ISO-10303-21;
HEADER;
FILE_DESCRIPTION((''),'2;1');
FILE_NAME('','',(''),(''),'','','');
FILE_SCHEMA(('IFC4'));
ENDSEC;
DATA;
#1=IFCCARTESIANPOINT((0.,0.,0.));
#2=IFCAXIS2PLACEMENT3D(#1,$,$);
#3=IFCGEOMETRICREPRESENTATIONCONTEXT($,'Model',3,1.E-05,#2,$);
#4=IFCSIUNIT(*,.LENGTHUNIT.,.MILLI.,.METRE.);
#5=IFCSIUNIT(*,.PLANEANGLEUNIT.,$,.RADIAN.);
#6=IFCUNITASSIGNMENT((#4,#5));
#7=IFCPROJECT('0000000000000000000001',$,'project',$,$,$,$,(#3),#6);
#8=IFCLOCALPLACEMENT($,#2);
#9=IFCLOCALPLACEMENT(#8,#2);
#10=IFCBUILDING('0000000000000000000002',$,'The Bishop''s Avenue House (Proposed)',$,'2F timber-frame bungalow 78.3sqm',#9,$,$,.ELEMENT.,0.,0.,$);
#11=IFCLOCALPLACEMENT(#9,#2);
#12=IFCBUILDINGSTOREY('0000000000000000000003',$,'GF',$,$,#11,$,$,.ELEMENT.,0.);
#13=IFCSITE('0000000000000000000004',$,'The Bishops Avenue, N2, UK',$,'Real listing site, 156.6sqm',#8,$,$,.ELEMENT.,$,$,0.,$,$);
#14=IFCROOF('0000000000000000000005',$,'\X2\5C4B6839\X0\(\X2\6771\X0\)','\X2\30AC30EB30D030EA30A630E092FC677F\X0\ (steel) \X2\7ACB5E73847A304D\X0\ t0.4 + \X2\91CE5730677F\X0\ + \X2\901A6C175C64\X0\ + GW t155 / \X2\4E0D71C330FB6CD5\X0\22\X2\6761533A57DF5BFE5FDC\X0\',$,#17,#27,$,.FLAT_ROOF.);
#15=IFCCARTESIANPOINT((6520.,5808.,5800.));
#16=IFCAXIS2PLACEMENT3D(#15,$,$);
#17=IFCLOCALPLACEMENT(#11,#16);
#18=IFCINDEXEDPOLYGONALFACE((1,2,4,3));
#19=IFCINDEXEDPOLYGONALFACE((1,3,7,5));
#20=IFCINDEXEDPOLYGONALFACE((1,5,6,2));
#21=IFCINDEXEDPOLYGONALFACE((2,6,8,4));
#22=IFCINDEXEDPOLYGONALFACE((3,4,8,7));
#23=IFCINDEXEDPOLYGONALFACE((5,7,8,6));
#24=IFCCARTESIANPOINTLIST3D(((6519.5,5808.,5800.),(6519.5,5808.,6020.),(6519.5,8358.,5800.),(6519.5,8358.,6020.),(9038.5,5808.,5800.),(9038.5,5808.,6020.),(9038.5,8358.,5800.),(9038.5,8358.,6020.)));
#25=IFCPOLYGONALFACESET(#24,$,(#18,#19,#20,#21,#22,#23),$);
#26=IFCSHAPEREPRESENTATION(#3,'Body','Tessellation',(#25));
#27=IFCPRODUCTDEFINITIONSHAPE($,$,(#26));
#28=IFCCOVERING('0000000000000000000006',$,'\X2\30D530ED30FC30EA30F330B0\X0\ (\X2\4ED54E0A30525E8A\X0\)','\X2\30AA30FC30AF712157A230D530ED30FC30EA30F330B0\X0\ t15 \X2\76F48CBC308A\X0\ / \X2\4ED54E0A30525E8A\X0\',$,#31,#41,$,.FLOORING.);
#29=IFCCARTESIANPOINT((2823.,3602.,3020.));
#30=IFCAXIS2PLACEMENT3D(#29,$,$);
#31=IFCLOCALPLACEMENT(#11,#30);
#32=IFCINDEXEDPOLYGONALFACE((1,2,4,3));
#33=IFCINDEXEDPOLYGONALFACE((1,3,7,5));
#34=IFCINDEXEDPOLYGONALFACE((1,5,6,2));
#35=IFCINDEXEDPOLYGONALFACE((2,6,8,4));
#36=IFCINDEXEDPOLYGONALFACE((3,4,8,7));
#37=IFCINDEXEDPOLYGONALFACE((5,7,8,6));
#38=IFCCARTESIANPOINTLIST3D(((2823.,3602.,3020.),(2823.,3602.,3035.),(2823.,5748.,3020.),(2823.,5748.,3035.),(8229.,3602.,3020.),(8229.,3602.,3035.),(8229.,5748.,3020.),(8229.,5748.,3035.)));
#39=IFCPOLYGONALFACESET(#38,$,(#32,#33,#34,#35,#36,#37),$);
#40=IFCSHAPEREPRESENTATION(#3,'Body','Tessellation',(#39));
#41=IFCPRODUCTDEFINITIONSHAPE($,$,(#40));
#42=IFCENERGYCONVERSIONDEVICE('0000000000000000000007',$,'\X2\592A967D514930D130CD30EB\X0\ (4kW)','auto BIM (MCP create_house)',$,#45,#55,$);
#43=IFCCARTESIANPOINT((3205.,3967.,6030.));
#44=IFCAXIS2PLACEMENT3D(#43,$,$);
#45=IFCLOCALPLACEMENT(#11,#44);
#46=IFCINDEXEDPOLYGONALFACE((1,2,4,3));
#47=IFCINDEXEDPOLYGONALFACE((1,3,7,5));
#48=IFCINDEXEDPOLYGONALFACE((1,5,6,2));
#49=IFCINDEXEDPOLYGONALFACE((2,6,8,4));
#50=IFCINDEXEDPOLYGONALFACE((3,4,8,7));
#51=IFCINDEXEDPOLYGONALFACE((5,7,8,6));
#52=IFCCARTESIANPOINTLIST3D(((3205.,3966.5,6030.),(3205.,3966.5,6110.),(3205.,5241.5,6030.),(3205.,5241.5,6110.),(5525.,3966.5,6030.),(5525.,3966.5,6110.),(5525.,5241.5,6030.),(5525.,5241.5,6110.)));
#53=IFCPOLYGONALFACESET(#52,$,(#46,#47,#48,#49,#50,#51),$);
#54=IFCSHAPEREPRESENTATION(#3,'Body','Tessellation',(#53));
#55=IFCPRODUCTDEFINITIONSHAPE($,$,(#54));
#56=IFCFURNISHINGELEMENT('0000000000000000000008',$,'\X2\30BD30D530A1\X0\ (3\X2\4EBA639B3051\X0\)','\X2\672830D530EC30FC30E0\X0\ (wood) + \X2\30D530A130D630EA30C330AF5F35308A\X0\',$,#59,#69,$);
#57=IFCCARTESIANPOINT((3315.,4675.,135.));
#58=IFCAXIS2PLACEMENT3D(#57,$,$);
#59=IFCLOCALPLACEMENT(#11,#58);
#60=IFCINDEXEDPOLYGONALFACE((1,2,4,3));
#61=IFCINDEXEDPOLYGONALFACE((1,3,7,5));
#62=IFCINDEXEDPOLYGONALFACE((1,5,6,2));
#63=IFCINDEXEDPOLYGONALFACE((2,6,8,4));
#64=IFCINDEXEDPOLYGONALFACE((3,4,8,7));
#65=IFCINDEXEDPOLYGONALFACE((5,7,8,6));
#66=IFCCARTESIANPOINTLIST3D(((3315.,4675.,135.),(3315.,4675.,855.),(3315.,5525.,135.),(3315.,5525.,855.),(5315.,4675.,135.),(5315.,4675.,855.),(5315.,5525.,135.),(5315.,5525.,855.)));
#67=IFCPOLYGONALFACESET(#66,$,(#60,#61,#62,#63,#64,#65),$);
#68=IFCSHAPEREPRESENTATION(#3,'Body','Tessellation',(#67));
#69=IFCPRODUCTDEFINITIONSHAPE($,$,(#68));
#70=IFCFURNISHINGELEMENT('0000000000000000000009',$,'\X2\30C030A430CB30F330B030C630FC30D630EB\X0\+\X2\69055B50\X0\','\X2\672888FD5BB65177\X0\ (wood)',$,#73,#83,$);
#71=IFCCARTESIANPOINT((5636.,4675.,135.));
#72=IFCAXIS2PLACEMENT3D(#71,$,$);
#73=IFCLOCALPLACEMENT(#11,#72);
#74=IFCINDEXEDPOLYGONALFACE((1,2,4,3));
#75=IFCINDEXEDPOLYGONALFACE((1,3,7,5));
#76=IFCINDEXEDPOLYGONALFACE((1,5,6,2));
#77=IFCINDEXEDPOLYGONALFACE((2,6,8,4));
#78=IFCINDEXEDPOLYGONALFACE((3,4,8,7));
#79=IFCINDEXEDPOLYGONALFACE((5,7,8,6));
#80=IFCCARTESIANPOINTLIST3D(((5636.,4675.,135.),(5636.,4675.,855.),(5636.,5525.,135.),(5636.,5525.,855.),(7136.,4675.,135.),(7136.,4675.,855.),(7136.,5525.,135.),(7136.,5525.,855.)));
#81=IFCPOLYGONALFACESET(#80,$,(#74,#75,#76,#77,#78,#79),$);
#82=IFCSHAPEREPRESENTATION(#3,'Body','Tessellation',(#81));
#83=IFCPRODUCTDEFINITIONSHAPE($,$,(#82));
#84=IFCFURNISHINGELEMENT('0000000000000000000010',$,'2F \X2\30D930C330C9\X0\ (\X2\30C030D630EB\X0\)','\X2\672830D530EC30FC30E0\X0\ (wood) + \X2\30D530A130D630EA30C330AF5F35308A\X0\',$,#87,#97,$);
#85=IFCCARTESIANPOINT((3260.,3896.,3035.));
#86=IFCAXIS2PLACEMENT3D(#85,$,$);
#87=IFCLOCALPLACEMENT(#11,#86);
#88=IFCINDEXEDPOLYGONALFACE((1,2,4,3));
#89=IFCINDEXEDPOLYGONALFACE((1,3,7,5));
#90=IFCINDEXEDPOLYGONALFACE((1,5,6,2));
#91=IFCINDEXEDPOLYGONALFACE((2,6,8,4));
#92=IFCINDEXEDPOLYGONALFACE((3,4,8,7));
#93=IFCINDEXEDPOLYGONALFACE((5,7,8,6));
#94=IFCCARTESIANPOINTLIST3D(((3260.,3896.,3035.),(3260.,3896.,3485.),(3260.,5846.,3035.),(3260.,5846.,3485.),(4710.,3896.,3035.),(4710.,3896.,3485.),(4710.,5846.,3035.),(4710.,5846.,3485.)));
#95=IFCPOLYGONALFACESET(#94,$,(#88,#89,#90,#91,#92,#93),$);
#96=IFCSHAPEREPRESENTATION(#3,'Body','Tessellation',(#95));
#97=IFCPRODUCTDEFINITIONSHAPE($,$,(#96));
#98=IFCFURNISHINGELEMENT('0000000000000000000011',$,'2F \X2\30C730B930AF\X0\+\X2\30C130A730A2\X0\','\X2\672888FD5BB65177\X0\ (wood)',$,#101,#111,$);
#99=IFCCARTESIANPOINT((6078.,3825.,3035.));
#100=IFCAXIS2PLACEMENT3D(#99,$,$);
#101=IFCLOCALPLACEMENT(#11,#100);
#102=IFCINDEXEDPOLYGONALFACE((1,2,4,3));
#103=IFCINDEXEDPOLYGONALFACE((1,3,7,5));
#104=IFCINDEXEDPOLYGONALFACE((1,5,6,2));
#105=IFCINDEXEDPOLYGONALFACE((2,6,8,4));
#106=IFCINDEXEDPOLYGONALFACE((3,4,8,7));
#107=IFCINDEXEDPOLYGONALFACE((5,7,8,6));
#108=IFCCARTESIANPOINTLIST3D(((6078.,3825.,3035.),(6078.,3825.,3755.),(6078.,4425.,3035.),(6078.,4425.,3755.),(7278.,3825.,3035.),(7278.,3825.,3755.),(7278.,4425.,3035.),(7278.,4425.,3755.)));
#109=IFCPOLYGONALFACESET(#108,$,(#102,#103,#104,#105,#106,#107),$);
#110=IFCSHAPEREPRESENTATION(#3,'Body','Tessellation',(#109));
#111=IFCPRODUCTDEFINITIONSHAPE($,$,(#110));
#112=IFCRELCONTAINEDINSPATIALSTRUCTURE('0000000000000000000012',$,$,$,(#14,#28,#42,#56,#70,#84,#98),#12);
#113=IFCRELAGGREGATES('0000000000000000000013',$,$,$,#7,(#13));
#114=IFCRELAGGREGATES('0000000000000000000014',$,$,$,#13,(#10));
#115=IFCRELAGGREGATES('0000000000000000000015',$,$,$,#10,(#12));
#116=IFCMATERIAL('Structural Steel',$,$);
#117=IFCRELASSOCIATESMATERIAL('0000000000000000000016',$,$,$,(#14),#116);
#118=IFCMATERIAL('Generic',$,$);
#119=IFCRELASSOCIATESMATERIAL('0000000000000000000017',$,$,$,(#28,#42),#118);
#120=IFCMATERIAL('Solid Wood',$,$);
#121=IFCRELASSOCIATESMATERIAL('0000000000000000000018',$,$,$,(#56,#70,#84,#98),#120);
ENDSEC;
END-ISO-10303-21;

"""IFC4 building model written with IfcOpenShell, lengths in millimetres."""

from ifc_helpers import new_model, si_unit, frame, frame_2d, origin, place, context, project, spatial, rectangle, extrude, material, element, save


model = new_model("IFC4")

# Units and contexts
model_context = context("Model", 3, precision=1e-05, world=origin())
ifc_project = project(units=[si_unit("LENGTHUNIT", "METRE", prefix="MILLI"), si_unit("PLANEANGLEUNIT", "RADIAN")], contexts=[model_context])

# Site, building, storey
site_placement = place(None, origin())
site = spatial("IfcSite", under=ifc_project, at=site_placement, Name="The Bishops Avenue, N2, UK", ObjectType="Real listing site, 156.6sqm", CompositionType="ELEMENT", RefElevation=0.0)
building_placement = place(site_placement, origin())
building = spatial("IfcBuilding", under=site, at=building_placement, Name="The Bishop's Avenue House (Proposed)", ObjectType="2F timber-frame bungalow 78.3sqm", CompositionType="ELEMENT", ElevationOfRefHeight=0.0, ElevationOfTerrain=0.0)
storey_placement = place(building_placement, origin())
storey = spatial("IfcBuildingStorey", under=building, at=storey_placement, Name="GF", CompositionType="ELEMENT", Elevation=0.0)

# Shared definitions
ifc_material_1 = material(Name="Solid Wood")

# Roof
ifc_material_2 = material(Name="Structural Steel")
roof_1_placement = place(storey_placement, frame((6520.0, 5808.0, 5800.0)))
element("IfcRoof", 1, at=roof_1_placement, inside=storey, material=ifc_material_2, Name="屋根(東)", Description="ガルバリウム鋼板 (steel) 立平葺き t0.4 + 野地板 + 通気層 + GW t155 / 不燃・法22条区域対応", PredefinedType="FLAT_ROOF", context=model_context, shape_type="SweptSolid", body=[
    extrude(rectangle(XDim=2519.0, YDim=2550.0, at=frame_2d((1259.0, 1275.0))), frame((6520.0, 5808.0, 5800.0)), (0.0, 0.0, 1.0), 220.0),
])

# Covering
ifc_material_3 = material(Name="Generic")
covering_placement = place(storey_placement, frame((2823.0, 3602.0, 3020.0)))
element("IfcCovering", 2, at=covering_placement, inside=storey, material=ifc_material_3, Name="フローリング (仕上げ床)", Description="オーク無垢フローリング t15 直貼り / 仕上げ床", PredefinedType="FLOORING", context=model_context, shape_type="SweptSolid", body=[
    extrude(rectangle(XDim=5406.0, YDim=2146.0, at=frame_2d((2703.0, 1073.0))), frame((2823.0, 3602.0, 3020.0)), (0.0, 0.0, 1.0), 15.0),
])

# Energy conversion device
energy_conversion_device_placement = place(storey_placement, frame((3205.0, 3967.0, 6030.0)))
element("IfcEnergyConversionDevice", 3, at=energy_conversion_device_placement, inside=storey, material=ifc_material_3, Name="太陽光パネル (4kW)", Description="auto BIM (MCP create_house)", context=model_context, shape_type="SweptSolid", body=[
    extrude(rectangle(XDim=2320.0, YDim=1275.0, at=frame_2d((1160.0, 637.0))), frame((3205.0, 3967.0, 6030.0)), (0.0, 0.0, 1.0), 80.0),
])

# Furnishing elements
furnishing_1_placement = place(storey_placement, frame((3315.0, 4675.0, 135.0)))
element("IfcFurnishingElement", 4, at=furnishing_1_placement, inside=storey, material=ifc_material_1, Name="ソファ (3人掛け)", Description="木フレーム (wood) + ファブリック張り", context=model_context, shape_type="SweptSolid", body=[
    extrude(rectangle(XDim=2000.0, YDim=850.0, at=frame_2d((1000.0, 425.0))), frame((3315.0, 4675.0, 135.0)), (0.0, 0.0, 1.0), 720.0),
])
furnishing_2_placement = place(storey_placement, frame((5636.0, 4675.0, 135.0)))
element("IfcFurnishingElement", 5, at=furnishing_2_placement, inside=storey, material=ifc_material_1, Name="ダイニングテーブル+椅子", Description="木製家具 (wood)", context=model_context, shape_type="SweptSolid", body=[
    extrude(rectangle(XDim=1500.0, YDim=850.0, at=frame_2d((750.0, 425.0))), frame((5636.0, 4675.0, 135.0)), (0.0, 0.0, 1.0), 720.0),
])
furnishing_3_placement = place(storey_placement, frame((3260.0, 3896.0, 3035.0)))
element("IfcFurnishingElement", 6, at=furnishing_3_placement, inside=storey, material=ifc_material_1, Name="2F ベッド (ダブル)", Description="木フレーム (wood) + ファブリック張り", context=model_context, shape_type="SweptSolid", body=[
    extrude(rectangle(XDim=1450.0, YDim=1950.0, at=frame_2d((725.0, 975.0))), frame((3260.0, 3896.0, 3035.0)), (0.0, 0.0, 1.0), 450.0),
])
furnishing_4_placement = place(storey_placement, frame((6078.0, 3825.0, 3035.0)))
element("IfcFurnishingElement", 7, at=furnishing_4_placement, inside=storey, material=ifc_material_1, Name="2F デスク+チェア", Description="木製家具 (wood)", context=model_context, shape_type="SweptSolid", body=[
    extrude(rectangle(XDim=1200.0, YDim=600.0, at=frame_2d((600.0, 300.0))), frame((6078.0, 3825.0, 3035.0)), (0.0, 0.0, 1.0), 720.0),
])

save(model, "model.ifc")
